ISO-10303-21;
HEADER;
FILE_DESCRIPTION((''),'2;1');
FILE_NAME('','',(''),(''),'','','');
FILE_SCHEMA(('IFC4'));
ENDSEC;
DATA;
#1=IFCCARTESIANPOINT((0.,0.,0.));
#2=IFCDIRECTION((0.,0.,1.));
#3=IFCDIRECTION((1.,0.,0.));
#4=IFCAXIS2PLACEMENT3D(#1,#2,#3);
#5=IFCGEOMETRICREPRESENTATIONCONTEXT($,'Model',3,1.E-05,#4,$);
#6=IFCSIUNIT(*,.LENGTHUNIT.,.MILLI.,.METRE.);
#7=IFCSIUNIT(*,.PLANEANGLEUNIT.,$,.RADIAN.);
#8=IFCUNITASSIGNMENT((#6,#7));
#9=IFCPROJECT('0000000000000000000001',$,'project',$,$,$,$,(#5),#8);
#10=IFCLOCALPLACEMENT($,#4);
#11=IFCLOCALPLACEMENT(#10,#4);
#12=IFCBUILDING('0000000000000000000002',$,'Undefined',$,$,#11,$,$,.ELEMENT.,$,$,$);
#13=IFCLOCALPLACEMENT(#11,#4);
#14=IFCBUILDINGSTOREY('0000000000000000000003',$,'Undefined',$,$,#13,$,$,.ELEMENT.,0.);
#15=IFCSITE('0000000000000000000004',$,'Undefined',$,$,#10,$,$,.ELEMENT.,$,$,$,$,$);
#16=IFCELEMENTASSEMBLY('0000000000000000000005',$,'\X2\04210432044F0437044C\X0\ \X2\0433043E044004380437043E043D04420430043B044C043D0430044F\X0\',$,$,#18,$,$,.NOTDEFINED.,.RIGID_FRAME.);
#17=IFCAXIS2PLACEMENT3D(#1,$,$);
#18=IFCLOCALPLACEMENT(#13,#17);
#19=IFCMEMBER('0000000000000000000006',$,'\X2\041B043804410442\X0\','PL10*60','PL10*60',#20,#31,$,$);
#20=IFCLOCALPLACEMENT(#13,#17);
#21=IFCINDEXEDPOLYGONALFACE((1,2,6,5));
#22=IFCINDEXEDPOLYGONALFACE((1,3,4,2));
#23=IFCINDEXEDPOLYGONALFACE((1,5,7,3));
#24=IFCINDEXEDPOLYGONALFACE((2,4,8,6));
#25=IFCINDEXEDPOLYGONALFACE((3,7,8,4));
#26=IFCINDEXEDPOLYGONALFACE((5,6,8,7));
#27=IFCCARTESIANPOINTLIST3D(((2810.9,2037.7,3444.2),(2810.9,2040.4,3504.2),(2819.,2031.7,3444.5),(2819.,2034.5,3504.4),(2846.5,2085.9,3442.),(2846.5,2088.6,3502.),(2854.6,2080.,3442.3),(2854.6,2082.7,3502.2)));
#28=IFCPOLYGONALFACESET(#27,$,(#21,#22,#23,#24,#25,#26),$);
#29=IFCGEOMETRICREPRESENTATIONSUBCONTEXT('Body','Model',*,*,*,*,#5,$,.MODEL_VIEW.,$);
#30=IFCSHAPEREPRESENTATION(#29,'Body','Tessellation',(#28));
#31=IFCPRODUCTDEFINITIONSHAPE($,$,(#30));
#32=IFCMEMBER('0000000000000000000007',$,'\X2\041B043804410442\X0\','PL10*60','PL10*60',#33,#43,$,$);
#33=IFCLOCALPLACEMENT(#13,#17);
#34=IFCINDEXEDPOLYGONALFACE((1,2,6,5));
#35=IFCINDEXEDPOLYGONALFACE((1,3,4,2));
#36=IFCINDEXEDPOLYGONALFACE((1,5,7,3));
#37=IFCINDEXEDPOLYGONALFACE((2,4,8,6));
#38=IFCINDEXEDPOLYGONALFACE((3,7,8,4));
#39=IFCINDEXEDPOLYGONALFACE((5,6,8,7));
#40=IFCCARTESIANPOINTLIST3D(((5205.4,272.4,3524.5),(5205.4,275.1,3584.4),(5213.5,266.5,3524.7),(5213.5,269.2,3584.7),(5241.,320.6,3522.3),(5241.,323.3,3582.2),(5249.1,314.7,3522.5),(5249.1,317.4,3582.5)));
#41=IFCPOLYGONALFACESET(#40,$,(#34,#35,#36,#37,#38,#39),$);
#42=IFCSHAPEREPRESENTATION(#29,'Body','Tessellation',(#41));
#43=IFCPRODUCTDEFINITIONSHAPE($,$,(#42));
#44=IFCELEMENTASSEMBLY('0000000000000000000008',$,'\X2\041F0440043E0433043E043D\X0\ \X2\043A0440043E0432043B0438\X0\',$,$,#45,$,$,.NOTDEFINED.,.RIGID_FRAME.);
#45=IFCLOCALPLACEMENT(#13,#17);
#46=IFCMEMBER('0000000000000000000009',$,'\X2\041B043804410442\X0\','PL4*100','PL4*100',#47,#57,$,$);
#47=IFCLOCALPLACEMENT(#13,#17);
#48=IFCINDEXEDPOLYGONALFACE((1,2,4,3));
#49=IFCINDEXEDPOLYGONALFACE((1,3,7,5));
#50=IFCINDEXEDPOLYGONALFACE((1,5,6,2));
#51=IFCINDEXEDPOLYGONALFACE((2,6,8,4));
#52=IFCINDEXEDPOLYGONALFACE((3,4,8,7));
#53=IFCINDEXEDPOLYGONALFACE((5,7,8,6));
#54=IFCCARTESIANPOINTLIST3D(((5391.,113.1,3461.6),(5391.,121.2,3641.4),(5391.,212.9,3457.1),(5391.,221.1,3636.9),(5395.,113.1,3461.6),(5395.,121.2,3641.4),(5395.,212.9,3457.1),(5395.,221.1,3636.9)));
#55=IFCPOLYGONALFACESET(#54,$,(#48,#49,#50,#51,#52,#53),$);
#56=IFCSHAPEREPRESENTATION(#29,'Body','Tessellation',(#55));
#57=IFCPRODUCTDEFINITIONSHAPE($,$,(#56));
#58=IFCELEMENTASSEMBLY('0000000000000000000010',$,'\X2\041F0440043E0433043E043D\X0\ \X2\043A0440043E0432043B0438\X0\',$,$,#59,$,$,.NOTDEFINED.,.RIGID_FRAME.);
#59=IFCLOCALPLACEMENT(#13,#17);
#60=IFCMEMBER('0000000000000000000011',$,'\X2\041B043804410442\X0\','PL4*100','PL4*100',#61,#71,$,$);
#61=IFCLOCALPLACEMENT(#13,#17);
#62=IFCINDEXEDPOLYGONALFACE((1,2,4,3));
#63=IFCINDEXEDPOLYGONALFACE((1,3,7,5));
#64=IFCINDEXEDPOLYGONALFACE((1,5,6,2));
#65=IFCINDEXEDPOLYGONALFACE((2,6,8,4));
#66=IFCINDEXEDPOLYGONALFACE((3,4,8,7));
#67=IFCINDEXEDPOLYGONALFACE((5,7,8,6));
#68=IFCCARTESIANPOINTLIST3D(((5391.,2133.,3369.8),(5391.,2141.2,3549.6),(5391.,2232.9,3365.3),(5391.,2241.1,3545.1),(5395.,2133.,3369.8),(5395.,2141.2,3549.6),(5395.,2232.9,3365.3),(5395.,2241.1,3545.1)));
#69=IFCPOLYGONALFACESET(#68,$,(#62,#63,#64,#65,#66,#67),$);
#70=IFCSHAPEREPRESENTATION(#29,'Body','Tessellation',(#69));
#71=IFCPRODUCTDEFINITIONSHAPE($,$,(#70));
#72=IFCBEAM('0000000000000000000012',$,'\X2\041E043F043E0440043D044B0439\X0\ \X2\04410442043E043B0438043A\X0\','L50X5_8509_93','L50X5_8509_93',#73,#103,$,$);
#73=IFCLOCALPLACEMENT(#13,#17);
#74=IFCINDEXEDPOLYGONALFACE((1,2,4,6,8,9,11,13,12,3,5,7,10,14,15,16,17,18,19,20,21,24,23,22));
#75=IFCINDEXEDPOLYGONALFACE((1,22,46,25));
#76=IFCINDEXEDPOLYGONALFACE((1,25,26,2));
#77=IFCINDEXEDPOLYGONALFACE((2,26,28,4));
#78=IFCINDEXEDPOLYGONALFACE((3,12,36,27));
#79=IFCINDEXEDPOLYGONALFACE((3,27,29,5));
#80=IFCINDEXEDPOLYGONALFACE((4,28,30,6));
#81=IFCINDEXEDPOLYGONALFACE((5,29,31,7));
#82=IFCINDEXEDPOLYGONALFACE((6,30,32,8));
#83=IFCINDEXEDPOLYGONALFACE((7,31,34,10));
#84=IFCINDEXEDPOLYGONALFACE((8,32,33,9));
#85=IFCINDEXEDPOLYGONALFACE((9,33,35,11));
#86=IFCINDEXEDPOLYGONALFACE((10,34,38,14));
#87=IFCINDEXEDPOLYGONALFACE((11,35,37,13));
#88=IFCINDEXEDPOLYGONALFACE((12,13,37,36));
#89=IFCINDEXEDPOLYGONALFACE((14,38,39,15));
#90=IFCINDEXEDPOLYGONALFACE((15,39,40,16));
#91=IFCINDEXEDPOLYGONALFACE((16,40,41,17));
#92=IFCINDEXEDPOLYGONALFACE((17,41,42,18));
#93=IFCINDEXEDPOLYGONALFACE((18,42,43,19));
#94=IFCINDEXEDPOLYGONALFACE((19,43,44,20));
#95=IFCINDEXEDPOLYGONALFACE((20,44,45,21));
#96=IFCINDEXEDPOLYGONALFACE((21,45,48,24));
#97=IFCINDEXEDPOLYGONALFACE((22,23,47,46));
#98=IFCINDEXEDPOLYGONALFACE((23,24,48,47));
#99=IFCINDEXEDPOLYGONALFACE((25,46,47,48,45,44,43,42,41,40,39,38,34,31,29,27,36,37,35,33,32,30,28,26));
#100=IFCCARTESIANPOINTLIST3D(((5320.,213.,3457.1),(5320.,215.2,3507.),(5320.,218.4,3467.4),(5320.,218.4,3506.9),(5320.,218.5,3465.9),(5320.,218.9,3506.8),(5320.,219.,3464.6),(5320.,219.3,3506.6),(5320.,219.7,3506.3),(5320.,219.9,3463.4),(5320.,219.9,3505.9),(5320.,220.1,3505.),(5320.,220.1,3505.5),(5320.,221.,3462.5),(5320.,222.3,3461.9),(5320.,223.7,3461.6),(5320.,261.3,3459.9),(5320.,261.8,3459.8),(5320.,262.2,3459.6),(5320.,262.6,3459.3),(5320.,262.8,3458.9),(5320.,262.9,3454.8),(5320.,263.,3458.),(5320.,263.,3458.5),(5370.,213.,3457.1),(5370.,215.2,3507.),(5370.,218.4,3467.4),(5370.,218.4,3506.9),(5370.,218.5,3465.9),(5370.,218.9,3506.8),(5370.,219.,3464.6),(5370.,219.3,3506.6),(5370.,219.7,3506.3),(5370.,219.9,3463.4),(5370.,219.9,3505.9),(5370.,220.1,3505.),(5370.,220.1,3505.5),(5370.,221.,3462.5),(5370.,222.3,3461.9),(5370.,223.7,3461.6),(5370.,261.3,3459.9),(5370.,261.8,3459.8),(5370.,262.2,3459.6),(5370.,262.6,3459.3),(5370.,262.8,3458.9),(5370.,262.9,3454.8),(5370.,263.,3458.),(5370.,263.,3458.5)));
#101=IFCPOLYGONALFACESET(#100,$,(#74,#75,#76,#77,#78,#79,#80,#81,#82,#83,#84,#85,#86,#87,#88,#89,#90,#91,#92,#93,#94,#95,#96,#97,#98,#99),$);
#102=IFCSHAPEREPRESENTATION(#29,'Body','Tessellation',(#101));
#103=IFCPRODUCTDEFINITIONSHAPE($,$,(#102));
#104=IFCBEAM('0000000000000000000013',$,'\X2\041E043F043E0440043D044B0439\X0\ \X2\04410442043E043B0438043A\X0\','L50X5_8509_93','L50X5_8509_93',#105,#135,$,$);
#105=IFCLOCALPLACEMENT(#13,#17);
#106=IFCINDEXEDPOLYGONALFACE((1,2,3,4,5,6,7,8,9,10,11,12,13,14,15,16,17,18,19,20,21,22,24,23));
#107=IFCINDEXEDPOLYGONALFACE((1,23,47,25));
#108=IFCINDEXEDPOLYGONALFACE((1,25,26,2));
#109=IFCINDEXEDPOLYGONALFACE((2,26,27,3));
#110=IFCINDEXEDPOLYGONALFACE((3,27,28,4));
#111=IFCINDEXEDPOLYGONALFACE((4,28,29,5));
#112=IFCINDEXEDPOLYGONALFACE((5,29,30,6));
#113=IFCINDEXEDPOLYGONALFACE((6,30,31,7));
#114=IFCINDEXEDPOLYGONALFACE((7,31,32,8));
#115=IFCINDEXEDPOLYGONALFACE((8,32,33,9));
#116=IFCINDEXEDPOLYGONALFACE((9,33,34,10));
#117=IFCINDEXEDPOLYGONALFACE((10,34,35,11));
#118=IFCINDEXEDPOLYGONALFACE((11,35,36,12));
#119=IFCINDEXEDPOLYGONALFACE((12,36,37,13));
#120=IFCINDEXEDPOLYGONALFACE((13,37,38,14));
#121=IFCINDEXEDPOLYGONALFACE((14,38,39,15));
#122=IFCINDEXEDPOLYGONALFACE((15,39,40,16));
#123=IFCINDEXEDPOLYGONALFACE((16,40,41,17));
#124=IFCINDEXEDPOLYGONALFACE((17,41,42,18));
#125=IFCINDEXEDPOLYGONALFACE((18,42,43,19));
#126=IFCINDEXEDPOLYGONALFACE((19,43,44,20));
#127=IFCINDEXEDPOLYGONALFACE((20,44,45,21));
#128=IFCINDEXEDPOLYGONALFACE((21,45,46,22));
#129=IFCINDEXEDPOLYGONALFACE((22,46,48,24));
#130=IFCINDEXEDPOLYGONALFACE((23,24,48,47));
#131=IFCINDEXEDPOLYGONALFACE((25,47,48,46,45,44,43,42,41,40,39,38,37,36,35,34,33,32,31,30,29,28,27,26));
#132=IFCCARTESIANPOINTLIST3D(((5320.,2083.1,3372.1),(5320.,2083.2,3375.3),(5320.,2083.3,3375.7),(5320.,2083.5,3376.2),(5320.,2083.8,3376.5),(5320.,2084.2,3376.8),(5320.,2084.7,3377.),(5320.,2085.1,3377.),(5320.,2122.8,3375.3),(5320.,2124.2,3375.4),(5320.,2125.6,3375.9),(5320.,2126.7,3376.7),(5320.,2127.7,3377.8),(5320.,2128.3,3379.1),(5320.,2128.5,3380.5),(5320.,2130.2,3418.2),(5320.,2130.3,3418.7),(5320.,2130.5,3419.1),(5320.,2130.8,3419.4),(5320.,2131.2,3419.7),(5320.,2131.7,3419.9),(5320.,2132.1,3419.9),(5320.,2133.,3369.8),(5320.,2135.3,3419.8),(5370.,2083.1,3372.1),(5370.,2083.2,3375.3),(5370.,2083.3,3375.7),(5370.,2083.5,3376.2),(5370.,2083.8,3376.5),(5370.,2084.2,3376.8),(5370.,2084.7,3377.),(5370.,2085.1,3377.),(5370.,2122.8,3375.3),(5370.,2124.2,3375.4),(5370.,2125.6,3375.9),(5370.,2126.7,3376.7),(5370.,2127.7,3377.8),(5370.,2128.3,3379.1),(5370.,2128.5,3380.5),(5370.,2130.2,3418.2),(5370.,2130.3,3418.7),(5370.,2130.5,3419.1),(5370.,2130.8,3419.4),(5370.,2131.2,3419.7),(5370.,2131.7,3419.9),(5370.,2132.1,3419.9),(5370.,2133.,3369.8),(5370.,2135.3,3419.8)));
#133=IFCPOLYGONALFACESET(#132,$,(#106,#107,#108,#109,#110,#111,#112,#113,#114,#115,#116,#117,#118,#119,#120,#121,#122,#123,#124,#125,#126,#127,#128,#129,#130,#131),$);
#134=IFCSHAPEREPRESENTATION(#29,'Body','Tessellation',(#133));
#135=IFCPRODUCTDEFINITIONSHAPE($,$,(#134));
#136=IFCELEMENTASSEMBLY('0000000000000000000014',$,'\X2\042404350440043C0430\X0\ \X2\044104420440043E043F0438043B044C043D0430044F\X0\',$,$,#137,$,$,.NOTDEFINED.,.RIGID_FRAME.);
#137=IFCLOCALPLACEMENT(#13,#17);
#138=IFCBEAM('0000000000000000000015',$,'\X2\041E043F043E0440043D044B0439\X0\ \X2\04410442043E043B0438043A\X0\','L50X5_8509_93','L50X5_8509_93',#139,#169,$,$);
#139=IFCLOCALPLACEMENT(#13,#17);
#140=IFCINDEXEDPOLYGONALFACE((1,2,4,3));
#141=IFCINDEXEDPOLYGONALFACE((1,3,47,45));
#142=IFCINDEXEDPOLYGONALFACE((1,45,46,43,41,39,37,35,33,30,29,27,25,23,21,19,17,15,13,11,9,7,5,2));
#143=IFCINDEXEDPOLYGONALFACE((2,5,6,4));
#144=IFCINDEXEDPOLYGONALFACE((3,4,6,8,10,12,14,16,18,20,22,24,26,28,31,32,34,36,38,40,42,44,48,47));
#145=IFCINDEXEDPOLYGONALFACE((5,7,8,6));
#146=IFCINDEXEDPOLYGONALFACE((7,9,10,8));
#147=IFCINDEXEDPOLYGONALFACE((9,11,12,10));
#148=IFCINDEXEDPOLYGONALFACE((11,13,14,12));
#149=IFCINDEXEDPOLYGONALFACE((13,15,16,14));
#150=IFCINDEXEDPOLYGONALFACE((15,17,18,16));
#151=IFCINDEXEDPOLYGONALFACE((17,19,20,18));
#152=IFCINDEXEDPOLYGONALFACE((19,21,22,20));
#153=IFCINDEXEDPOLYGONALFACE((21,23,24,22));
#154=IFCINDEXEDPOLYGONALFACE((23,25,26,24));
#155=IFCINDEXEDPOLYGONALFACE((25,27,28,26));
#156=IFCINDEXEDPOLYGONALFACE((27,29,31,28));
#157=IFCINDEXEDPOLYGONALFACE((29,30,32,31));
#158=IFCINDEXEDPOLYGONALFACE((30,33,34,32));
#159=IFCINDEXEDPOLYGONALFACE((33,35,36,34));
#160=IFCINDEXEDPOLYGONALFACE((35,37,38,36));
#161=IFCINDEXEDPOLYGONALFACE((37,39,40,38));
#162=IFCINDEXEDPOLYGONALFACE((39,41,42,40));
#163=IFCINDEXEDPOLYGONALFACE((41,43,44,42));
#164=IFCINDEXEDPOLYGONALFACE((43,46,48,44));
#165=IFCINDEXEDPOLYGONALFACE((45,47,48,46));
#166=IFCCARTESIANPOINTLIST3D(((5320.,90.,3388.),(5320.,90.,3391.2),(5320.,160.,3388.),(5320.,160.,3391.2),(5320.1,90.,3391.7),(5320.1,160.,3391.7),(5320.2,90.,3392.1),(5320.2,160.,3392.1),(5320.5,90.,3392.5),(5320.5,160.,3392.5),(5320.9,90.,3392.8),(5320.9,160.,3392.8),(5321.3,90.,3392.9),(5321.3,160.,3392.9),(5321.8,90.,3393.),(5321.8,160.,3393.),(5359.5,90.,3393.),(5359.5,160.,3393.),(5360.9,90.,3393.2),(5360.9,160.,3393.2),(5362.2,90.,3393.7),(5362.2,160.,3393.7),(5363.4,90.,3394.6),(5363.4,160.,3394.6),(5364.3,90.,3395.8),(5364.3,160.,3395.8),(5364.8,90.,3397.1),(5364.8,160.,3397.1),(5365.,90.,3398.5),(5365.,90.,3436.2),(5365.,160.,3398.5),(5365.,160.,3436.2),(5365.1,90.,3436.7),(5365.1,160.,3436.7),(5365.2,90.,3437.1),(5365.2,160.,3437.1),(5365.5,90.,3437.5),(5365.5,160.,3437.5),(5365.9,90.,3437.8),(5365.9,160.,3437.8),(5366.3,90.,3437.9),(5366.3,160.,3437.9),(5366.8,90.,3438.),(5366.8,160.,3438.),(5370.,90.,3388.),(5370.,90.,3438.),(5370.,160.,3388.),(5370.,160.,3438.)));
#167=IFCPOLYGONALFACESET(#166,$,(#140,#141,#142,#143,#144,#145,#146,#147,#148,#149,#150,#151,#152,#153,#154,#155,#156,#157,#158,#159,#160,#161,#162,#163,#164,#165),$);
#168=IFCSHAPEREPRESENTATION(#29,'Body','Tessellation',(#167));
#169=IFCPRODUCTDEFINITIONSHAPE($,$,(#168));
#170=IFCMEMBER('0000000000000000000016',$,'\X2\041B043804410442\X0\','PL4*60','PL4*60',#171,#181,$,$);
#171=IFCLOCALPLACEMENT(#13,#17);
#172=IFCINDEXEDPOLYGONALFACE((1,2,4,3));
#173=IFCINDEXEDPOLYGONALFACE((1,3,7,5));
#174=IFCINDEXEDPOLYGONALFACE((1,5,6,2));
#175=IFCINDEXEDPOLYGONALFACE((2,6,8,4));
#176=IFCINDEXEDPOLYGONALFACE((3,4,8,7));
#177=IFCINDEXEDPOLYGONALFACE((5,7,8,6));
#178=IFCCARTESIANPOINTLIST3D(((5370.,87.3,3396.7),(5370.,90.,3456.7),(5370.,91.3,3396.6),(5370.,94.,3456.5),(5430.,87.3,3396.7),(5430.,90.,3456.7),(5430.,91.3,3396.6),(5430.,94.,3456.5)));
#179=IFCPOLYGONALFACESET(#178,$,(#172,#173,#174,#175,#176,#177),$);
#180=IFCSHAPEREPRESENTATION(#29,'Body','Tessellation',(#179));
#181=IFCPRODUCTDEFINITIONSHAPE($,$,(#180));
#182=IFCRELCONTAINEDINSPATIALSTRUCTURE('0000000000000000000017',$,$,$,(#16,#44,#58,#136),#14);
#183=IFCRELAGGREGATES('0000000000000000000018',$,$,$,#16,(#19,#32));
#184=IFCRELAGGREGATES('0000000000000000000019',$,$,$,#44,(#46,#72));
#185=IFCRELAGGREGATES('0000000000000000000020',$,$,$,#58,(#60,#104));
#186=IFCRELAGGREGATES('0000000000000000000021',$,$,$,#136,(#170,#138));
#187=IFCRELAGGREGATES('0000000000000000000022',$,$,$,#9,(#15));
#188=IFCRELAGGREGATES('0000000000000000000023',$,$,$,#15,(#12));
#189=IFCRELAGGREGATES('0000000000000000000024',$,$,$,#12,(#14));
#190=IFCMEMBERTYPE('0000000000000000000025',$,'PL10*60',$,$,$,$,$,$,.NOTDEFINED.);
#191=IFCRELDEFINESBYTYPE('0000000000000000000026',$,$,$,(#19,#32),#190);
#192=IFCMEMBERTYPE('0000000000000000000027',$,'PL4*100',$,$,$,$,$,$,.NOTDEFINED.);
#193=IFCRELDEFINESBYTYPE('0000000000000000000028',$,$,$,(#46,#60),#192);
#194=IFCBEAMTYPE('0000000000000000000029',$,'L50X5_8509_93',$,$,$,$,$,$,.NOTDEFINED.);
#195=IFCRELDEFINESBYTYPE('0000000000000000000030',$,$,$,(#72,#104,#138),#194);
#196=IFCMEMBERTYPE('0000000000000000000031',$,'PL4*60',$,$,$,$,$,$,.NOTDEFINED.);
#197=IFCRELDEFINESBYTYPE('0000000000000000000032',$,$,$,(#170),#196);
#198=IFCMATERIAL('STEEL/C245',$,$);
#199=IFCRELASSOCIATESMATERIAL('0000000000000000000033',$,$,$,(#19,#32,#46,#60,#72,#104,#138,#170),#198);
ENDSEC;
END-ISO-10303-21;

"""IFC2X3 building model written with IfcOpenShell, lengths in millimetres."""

from ifc_helpers import new_model, si_unit, frame, origin_with_axes, origin_2d_with_axis, place, context, subcontext, project, spatial, rectangle, l_section, extrude, material, type_object, element, aggregate, save


model = new_model("IFC2X3")

# Units and contexts
model_context = context("Model", 3, precision=1e-05, world=origin_with_axes())
body_context = subcontext(model_context, "Body", "Model", "MODEL_VIEW")
ifc_project = project(units=[si_unit("LENGTHUNIT", "METRE", prefix="MILLI"), si_unit("PLANEANGLEUNIT", "RADIAN")], contexts=[model_context])

# Site, building, storey
site_placement = place(None, origin_with_axes())
site = spatial("IfcSite", under=ifc_project, at=site_placement, Name="Undefined", CompositionType="ELEMENT")
building_placement = place(site_placement, origin_with_axes())
building = spatial("IfcBuilding", under=site, at=building_placement, Name="Undefined", CompositionType="ELEMENT")
storey_placement = place(building_placement, origin_with_axes())
storey = spatial("IfcBuildingStorey", under=building, at=storey_placement, Name="Undefined", CompositionType="ELEMENT", Elevation=0.0)

# Shared definitions
ifc_material_1 = material(Name="STEEL/C245")

# Element assembly, members
assembly_1_placement = place(storey_placement, origin_with_axes())
assembly_1 = element("IfcElementAssembly", 1, at=assembly_1_placement, inside=storey, Name="Связь горизонтальная", AssemblyPlace="NOTDEFINED", PredefinedType="RIGID_FRAME")
member_type_1 = type_object("IfcMemberType", Name="PL10*60", PredefinedType="NOTDEFINED")
member_1_placement = place(assembly_1_placement, frame((2832.7, 2058.8, 3443.3), z_axis=(0.593795, 0.803786, -0.036536), x_axis=(0.0, 0.045408, 0.998969)))
member_1 = element("IfcMember", 2, at=member_1_placement, type_object=member_type_1, material=ifc_material_1, Name="Лист", Description="PL10*60", ObjectType="PL10*60", context=body_context, shape_type="SweptSolid", body=[
    extrude(rectangle(XDim=10.0, YDim=60.0, at=origin_2d_with_axis()), frame((60.0, 0.0, 0.0), z_axis=(-1.0, 0.0, 0.0), x_axis=(0.0, -1.0, 0.0)), (0.0, 0.0, 1.0), 60.0),
])
member_2_placement = place(assembly_1_placement, frame((5227.3, 296.3, 3583.4), z_axis=(0.593795, 0.803786, -0.036536), x_axis=(0.0, -0.045408, -0.998969)))
member_2 = element("IfcMember", 3, at=member_2_placement, type_object=member_type_1, material=ifc_material_1, Name="Лист", Description="PL10*60", ObjectType="PL10*60", context=body_context, shape_type="SweptSolid", body=[
    extrude(rectangle(XDim=10.0, YDim=60.0, at=origin_2d_with_axis()), frame((60.0, 0.0, 0.0), z_axis=(-1.0, 0.0, 0.0), x_axis=(0.0, -1.0, 0.0)), (0.0, 0.0, 1.0), 60.0),
])

# Element assemblies, members
assembly_2_placement = place(storey_placement, origin_with_axes())
assembly_2 = element("IfcElementAssembly", 4, at=assembly_2_placement, inside=storey, Name="Прогон кровли", AssemblyPlace="NOTDEFINED", PredefinedType="RIGID_FRAME")
member_type_2 = type_object("IfcMemberType", Name="PL4*100", PredefinedType="NOTDEFINED")
member_3_placement = place(assembly_2_placement, frame((5393.0, 163.0, 3459.4), z_axis=(0.0, 0.998969, -0.045408), x_axis=(0.0, 0.045408, 0.998969)))
member_3 = element("IfcMember", 5, at=member_3_placement, type_object=member_type_2, material=ifc_material_1, Name="Лист", Description="PL4*100", ObjectType="PL4*100", context=body_context, shape_type="SweptSolid", body=[
    extrude(rectangle(XDim=4.0, YDim=100.0, at=origin_2d_with_axis()), frame((180.0, 0.0, 0.0), z_axis=(-1.0, 0.0, 0.0), x_axis=(0.0, -1.0, 0.0)), (0.0, 0.0, 1.0), 180.0),
])
assembly_3_placement = place(storey_placement, origin_with_axes())
assembly_3 = element("IfcElementAssembly", 6, at=assembly_3_placement, inside=storey, Name="Прогон кровли", AssemblyPlace="NOTDEFINED", PredefinedType="RIGID_FRAME")
member_4_placement = place(assembly_3_placement, frame((5393.0, 2183.0, 3367.5), z_axis=(0.0, 0.998969, -0.045408), x_axis=(0.0, 0.045408, 0.998969)))
member_4 = element("IfcMember", 7, at=member_4_placement, type_object=member_type_2, material=ifc_material_1, Name="Лист", Description="PL4*100", ObjectType="PL4*100", context=body_context, shape_type="SweptSolid", body=[
    extrude(rectangle(XDim=4.0, YDim=100.0, at=origin_2d_with_axis()), frame((180.0, 0.0, 0.0), z_axis=(-1.0, 0.0, 0.0), x_axis=(0.0, -1.0, 0.0)), (0.0, 0.0, 1.0), 180.0),
])

# Beams
beam_type_1 = type_object("IfcBeamType", Name="L50X5_8509_93", PredefinedType="NOTDEFINED")
beam_1_placement = place(assembly_2_placement, frame((5320.0, 239.1, 3480.9), z_axis=(0.0, 0.998969, -0.045408), x_axis=(1.0, 0.0, 0.0)))
beam_1 = element("IfcBeam", 8, at=beam_1_placement, type_object=beam_type_1, material=ifc_material_1, Name="Опорный столик", Description="L50X5_8509_93", ObjectType="L50X5_8509_93", context=body_context, shape_type="SweptSolid", body=[
    extrude(l_section(Depth=50.0, Width=50.0, Thickness=5.0, FilletRadius=5.5, EdgeRadius=1.8, at=origin_2d_with_axis()), frame((50.0, 0.0, 0.0), z_axis=(-1.0, 0.0, 0.0), x_axis=(0.0, -1.0, 0.0)), (0.0, 0.0, 1.0), 50.0),
])
beam_2_placement = place(assembly_3_placement, frame((5370.0, 2109.2, 3395.9), z_axis=(0.0, -0.998969, 0.045408), x_axis=(-1.0, 0.0, 0.0)))
beam_2 = element("IfcBeam", 9, at=beam_2_placement, type_object=beam_type_1, material=ifc_material_1, Name="Опорный столик", Description="L50X5_8509_93", ObjectType="L50X5_8509_93", context=body_context, shape_type="SweptSolid", body=[
    extrude(l_section(Depth=50.0, Width=50.0, Thickness=5.0, FilletRadius=5.5, EdgeRadius=1.8, at=origin_2d_with_axis()), frame((50.0, 0.0, 0.0), z_axis=(-1.0, 0.0, 0.0), x_axis=(0.0, -1.0, 0.0)), (0.0, 0.0, 1.0), 50.0),
])

# Element assembly, beam, member
assembly_4_placement = place(storey_placement, origin_with_axes())
assembly_4 = element("IfcElementAssembly", 10, at=assembly_4_placement, inside=storey, Name="Ферма стропильная", AssemblyPlace="NOTDEFINED", PredefinedType="RIGID_FRAME")
beam_3_placement = place(assembly_4_placement, frame((5345.0, 90.0, 3413.0), z_axis=(-1.0, 0.0, 0.0), x_axis=(0.0, 1.0, 0.0)))
beam_3 = element("IfcBeam", 11, at=beam_3_placement, type_object=beam_type_1, material=ifc_material_1, Name="Опорный столик", Description="L50X5_8509_93", ObjectType="L50X5_8509_93", context=body_context, shape_type="SweptSolid", body=[
    extrude(l_section(Depth=50.0, Width=50.0, Thickness=5.0, FilletRadius=5.5, EdgeRadius=1.8, at=origin_2d_with_axis()), frame((70.0, 0.0, 0.0), z_axis=(-1.0, 0.0, 0.0), x_axis=(0.0, -1.0, 0.0)), (0.0, 0.0, 1.0), 70.0),
])
member_type_3 = type_object("IfcMemberType", Name="PL4*60", PredefinedType="NOTDEFINED")
member_5_placement = place(assembly_4_placement, frame((5400.0, 89.3, 3396.6), z_axis=(1.0, 0.0, 0.0), x_axis=(0.0, 0.045408, 0.998969)))
member_5 = element("IfcMember", 12, at=member_5_placement, type_object=member_type_3, material=ifc_material_1, Name="Лист", Description="PL4*60", ObjectType="PL4*60", context=body_context, shape_type="SweptSolid", body=[
    extrude(rectangle(XDim=4.0, YDim=60.0, at=origin_2d_with_axis()), frame((60.0, 0.0, 0.0), z_axis=(-1.0, 0.0, 0.0), x_axis=(0.0, -1.0, 0.0)), (0.0, 0.0, 1.0), 60.0),
])

aggregate(assembly_1, [member_1, member_2])
aggregate(assembly_2, [member_3, beam_1])
aggregate(assembly_3, [member_4, beam_2])
aggregate(assembly_4, [member_5, beam_3])

save(model, "model.ifc")
